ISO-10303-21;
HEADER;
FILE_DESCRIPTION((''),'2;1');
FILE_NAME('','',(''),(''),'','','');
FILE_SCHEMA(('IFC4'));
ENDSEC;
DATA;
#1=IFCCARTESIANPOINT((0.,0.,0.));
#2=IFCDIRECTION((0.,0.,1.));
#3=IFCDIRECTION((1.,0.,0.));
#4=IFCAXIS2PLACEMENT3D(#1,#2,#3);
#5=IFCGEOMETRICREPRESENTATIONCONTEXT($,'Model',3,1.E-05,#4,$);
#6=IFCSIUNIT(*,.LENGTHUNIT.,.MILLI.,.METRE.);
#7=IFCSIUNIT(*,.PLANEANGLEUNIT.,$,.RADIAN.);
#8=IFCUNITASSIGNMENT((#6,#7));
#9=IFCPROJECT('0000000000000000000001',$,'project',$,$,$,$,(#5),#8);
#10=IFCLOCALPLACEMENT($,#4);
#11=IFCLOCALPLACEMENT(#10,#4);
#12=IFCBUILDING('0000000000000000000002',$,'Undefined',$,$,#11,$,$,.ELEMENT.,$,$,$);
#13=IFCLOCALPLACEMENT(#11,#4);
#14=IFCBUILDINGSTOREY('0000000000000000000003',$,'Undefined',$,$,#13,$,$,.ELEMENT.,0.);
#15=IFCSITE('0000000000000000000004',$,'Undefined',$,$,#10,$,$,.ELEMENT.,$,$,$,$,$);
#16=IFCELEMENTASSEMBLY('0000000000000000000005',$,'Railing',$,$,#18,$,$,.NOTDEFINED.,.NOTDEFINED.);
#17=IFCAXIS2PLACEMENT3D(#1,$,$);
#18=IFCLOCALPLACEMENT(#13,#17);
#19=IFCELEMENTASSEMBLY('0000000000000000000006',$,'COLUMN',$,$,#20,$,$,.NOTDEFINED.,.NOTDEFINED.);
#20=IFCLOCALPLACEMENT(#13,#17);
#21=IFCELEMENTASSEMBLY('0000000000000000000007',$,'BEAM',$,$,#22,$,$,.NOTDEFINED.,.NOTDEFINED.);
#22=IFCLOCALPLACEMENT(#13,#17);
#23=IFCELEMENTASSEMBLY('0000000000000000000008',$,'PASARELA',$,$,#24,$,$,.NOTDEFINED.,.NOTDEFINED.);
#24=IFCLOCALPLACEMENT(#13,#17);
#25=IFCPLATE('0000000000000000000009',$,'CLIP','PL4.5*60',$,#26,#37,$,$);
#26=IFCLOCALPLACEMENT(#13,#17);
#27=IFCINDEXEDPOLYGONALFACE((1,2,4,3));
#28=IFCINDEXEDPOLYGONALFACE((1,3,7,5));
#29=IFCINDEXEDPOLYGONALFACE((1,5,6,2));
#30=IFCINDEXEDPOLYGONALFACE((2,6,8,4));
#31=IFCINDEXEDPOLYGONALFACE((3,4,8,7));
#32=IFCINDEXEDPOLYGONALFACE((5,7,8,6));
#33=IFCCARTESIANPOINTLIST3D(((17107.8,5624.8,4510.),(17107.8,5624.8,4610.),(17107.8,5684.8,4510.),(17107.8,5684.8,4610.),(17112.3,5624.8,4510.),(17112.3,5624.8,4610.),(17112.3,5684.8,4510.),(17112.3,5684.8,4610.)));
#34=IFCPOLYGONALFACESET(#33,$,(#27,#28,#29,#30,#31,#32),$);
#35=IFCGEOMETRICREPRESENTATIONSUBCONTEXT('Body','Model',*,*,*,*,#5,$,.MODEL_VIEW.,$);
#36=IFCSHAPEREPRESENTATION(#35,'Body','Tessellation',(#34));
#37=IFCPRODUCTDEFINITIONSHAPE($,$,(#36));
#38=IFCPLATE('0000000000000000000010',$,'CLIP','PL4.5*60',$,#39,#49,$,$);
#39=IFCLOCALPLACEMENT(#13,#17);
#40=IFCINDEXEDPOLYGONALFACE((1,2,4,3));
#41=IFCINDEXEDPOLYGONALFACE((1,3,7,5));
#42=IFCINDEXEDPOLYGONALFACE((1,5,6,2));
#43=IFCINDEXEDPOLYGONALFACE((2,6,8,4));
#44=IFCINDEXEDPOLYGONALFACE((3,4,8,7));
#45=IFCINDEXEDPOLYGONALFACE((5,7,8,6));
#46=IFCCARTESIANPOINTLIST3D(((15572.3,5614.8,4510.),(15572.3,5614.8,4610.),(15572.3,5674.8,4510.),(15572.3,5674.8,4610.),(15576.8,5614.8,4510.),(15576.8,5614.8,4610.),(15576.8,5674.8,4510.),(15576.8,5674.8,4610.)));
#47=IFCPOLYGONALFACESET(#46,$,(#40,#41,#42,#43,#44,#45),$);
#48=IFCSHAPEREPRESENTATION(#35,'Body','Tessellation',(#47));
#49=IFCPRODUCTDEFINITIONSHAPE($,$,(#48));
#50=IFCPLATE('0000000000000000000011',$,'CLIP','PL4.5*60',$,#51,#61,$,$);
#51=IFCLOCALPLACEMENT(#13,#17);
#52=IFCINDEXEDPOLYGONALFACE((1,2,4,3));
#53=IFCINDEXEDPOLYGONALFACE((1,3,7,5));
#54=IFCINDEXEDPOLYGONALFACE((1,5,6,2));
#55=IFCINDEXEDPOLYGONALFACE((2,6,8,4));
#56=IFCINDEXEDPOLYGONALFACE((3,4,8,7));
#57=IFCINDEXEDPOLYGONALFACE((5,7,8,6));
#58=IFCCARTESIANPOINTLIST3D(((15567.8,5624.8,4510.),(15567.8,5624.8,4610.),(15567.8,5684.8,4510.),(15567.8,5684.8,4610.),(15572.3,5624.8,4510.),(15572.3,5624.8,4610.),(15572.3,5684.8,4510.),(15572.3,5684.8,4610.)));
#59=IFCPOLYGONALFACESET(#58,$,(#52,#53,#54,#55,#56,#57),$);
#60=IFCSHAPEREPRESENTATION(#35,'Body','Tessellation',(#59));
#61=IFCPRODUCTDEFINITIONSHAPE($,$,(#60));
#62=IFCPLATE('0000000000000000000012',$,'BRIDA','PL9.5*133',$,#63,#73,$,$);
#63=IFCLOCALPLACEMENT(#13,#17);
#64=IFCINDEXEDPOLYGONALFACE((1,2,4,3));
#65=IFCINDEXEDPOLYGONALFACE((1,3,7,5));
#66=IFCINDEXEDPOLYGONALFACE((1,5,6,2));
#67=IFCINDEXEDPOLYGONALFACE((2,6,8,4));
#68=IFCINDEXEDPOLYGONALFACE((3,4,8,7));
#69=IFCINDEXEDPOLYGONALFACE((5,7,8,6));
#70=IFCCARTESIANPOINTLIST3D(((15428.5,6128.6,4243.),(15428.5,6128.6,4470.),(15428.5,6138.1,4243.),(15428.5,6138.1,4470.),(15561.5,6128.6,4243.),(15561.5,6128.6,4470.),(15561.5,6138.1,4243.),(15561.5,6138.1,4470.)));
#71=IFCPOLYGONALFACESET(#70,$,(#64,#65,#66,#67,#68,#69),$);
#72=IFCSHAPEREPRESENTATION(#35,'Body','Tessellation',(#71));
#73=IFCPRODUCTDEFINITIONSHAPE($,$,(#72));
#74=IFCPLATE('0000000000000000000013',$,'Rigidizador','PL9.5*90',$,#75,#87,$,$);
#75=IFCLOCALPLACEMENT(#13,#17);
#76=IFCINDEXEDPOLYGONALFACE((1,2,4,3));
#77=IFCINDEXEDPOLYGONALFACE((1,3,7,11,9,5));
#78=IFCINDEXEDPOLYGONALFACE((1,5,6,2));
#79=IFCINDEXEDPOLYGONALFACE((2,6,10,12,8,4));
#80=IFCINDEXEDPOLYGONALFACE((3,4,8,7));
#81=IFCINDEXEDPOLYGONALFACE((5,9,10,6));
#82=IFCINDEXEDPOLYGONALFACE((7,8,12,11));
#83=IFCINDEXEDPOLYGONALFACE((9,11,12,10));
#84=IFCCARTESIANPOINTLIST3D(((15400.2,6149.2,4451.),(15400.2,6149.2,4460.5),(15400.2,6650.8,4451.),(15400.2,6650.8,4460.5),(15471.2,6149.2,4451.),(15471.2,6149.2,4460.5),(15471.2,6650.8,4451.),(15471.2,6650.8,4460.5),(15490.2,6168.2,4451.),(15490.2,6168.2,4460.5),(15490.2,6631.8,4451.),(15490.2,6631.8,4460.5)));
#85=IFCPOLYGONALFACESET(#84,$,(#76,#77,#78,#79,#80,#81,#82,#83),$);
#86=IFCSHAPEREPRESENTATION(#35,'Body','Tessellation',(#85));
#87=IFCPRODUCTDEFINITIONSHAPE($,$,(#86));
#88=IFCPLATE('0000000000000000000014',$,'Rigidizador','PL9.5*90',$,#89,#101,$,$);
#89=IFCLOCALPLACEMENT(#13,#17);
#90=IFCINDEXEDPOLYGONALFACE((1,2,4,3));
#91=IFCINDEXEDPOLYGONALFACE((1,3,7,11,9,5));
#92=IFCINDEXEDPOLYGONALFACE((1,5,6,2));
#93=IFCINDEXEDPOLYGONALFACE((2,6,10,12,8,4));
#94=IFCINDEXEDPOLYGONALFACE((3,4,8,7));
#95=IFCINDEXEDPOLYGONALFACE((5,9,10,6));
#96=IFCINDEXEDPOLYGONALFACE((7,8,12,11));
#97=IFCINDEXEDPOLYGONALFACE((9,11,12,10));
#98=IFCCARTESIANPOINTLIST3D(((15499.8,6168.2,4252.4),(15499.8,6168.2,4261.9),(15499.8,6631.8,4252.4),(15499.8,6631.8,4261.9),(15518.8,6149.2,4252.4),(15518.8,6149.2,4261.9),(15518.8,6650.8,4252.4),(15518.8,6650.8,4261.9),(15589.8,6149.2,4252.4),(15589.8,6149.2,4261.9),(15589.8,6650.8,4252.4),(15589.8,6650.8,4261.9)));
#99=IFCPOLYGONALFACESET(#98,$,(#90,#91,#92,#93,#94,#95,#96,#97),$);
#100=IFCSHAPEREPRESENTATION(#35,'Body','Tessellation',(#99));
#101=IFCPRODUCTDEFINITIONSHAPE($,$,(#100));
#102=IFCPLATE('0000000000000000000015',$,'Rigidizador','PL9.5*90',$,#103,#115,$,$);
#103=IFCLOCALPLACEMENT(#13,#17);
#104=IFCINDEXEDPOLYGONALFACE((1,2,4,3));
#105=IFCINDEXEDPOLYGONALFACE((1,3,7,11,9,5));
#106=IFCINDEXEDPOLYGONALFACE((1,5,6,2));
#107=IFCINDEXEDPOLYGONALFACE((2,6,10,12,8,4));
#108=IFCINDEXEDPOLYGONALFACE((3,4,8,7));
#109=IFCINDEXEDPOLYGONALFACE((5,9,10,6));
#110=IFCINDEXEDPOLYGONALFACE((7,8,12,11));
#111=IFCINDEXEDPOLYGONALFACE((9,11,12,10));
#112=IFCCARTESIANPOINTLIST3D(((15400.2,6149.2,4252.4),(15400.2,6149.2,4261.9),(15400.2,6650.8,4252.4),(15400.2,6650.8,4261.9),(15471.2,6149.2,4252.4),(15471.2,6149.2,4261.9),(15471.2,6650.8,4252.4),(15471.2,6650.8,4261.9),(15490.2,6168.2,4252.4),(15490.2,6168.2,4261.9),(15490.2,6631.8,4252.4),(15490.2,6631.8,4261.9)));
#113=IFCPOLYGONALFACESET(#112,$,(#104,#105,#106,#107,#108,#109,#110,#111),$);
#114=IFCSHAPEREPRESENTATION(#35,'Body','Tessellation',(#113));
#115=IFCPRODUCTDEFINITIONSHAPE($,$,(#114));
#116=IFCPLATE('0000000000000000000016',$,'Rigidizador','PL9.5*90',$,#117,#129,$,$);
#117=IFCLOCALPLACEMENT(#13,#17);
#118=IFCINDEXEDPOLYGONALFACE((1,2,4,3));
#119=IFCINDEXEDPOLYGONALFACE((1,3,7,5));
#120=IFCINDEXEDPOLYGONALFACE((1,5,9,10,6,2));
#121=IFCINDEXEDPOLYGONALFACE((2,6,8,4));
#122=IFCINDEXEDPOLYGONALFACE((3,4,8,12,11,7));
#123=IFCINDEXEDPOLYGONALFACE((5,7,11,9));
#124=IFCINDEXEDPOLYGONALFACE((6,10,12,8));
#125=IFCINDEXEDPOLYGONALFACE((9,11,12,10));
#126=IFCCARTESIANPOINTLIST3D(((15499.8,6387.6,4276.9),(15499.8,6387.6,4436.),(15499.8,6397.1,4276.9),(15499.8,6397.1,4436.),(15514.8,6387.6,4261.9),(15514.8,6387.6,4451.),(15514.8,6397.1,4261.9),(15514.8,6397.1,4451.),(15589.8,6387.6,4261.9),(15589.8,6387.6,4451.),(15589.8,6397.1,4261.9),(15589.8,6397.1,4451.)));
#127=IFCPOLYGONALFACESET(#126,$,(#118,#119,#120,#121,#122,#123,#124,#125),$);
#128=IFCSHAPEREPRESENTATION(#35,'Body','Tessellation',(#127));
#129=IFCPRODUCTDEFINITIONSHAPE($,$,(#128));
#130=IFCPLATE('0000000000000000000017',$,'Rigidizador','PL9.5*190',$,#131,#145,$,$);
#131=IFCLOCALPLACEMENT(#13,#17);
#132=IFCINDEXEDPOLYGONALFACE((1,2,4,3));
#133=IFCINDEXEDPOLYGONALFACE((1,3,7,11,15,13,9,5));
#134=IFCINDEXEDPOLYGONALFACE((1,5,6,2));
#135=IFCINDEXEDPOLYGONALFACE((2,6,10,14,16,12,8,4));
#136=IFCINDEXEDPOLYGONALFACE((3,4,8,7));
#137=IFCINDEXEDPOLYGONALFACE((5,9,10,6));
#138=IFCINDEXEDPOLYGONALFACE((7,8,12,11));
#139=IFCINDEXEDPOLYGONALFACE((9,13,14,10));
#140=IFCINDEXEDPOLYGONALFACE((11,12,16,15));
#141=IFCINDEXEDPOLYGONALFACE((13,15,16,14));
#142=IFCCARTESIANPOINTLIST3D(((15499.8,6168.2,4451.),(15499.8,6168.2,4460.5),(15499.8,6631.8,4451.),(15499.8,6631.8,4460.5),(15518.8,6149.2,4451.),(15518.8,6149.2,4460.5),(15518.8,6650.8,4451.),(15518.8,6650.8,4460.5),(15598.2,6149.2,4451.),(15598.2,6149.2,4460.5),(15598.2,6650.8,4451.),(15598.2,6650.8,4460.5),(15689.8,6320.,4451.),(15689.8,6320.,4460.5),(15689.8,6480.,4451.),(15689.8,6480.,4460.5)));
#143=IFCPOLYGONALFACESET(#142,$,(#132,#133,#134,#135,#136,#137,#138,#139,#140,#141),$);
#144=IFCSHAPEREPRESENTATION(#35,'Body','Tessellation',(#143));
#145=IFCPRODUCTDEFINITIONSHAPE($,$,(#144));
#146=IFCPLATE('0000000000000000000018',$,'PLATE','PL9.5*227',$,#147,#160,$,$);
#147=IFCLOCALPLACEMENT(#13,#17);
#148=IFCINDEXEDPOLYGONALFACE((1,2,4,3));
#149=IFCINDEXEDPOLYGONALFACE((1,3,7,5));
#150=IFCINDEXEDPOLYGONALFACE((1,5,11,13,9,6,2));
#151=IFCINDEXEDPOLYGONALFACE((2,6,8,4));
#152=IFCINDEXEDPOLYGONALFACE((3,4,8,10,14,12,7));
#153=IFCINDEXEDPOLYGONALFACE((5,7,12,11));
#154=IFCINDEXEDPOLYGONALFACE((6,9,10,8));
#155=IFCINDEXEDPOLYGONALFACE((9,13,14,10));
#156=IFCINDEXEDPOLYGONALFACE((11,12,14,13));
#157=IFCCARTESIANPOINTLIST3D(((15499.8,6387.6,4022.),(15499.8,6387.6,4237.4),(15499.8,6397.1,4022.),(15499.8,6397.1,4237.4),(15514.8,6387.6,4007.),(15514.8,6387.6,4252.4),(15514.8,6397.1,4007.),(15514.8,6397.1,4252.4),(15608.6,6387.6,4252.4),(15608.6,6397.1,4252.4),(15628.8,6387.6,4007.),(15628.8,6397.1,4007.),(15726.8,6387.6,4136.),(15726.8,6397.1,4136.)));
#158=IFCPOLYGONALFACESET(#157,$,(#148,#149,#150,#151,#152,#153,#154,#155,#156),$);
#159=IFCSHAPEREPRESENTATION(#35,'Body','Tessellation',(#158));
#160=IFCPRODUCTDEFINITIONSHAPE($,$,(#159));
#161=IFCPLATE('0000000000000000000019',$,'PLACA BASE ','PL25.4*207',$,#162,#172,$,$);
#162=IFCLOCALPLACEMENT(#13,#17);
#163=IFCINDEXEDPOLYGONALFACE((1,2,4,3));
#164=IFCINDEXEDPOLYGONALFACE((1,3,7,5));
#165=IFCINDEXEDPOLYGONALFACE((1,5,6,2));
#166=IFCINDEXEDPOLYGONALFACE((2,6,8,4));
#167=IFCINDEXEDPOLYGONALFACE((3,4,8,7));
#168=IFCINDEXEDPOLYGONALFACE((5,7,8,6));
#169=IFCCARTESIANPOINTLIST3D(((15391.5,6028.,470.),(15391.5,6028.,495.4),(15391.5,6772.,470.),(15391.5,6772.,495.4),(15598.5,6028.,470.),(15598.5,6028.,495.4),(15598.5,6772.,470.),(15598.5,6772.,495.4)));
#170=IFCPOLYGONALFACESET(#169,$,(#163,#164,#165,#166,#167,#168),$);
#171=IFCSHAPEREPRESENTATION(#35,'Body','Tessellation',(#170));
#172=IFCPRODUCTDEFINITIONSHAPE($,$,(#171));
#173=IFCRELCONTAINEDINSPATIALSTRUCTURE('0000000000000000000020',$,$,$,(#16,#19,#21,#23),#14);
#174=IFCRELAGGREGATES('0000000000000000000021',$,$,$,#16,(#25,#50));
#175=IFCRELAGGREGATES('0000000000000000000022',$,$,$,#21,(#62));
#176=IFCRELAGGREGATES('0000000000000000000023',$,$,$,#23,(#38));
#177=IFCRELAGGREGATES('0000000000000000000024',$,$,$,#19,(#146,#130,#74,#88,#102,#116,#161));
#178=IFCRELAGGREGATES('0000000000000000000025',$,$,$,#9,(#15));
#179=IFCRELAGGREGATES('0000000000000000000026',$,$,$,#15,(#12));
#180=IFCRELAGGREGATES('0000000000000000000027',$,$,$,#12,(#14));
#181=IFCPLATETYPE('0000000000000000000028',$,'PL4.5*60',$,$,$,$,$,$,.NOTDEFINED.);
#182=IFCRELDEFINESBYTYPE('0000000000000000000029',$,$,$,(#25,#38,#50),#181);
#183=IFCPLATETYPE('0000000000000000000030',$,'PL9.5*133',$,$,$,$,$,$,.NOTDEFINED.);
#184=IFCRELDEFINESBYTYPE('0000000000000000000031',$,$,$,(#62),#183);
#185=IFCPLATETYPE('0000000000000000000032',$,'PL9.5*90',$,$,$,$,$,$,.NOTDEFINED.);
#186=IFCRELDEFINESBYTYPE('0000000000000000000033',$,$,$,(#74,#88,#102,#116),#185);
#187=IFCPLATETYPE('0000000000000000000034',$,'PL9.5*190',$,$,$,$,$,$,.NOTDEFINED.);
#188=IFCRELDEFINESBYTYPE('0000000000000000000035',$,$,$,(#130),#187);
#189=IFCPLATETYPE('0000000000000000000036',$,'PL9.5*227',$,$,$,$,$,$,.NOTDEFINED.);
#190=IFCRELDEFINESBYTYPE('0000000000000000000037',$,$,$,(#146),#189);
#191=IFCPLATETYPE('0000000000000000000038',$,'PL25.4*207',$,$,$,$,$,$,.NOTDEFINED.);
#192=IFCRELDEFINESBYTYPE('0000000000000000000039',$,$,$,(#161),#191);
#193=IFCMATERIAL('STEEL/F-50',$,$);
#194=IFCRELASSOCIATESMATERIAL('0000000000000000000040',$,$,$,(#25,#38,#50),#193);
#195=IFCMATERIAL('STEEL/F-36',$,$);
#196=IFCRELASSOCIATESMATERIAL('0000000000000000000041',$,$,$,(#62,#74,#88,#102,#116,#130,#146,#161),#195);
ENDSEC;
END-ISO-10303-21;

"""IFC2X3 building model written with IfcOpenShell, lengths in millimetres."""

from ifc_helpers import new_model, si_unit, frame, origin_with_axes, place, context, subcontext, project, spatial, polyline, outline, extrude, material, type_object, element, aggregate, save


model = new_model("IFC2X3")

# Units and contexts
model_context = context("Model", 3, precision=1e-05, world=origin_with_axes())
body_context = subcontext(model_context, "Body", "Model", "MODEL_VIEW")
ifc_project = project(units=[si_unit("LENGTHUNIT", "METRE", prefix="MILLI"), si_unit("PLANEANGLEUNIT", "RADIAN")], contexts=[model_context])

# Site, building, storey
site_placement = place(None, origin_with_axes())
site = spatial("IfcSite", under=ifc_project, at=site_placement, Name="Undefined", CompositionType="ELEMENT")
building_placement = place(site_placement, origin_with_axes())
building = spatial("IfcBuilding", under=site, at=building_placement, Name="Undefined", CompositionType="ELEMENT")
storey_placement = place(building_placement, origin_with_axes())
storey = spatial("IfcBuildingStorey", under=building, at=storey_placement, Name="Undefined", CompositionType="ELEMENT", Elevation=0.0)

# Element assembly
assembly_1_placement = place(storey_placement, origin_with_axes())
assembly_1 = element("IfcElementAssembly", 1, at=assembly_1_placement, inside=storey, Name="Railing", AssemblyPlace="NOTDEFINED", PredefinedType="NOTDEFINED")

# Element assembly
assembly_2_placement = place(storey_placement, origin_with_axes())
assembly_2 = element("IfcElementAssembly", 2, at=assembly_2_placement, inside=storey, Name="COLUMN", AssemblyPlace="NOTDEFINED", PredefinedType="NOTDEFINED")
ifc_material_1 = material(Name="STEEL/F-36")

# Element assembly
assembly_3_placement = place(storey_placement, origin_with_axes())
assembly_3 = element("IfcElementAssembly", 3, at=assembly_3_placement, inside=storey, Name="BEAM", AssemblyPlace="NOTDEFINED", PredefinedType="NOTDEFINED")

# Element assembly
assembly_4_placement = place(storey_placement, origin_with_axes())
assembly_4 = element("IfcElementAssembly", 4, at=assembly_4_placement, inside=storey, Name="PASARELA", AssemblyPlace="NOTDEFINED", PredefinedType="NOTDEFINED")
ifc_material_2 = material(Name="STEEL/F-50")
plate_type_1 = type_object("IfcPlateType", Name="PL4.5*60", PredefinedType="NOTDEFINED")

# Plates
plate_1_placement = place(assembly_1_placement, frame((17110.0, 5684.8, 4510.0), z_axis=(-1.0, 0.0, 0.0), x_axis=(0.000001, -1.0, 0.000014)))
plate_1 = element("IfcPlate", 5, at=plate_1_placement, type_object=plate_type_1, material=ifc_material_2, Name="CLIP", Description="PL4.5*60", context=body_context, shape_type="SweptSolid", body=[
    extrude(outline(polyline([(0.0, 0.0), (60.0, 0.0), (60.0, 100.0), (0.0, 100.0), (0.0, 0.0)])), frame((0.0, 0.0, -2.2), z_axis=(0.0, 0.0, 1.0), x_axis=(1.0, 0.0, 0.0)), (0.0, 0.0, 1.0), 4.5),
])
plate_2_placement = place(assembly_4_placement, frame((15574.5, 5674.8, 4510.0), z_axis=(-1.0, 0.0, 0.0), x_axis=(0.000001, -1.0, 0.000014)))
plate_2 = element("IfcPlate", 6, at=plate_2_placement, type_object=plate_type_1, material=ifc_material_2, Name="CLIP", Description="PL4.5*60", context=body_context, shape_type="SweptSolid", body=[
    extrude(outline(polyline([(0.0, 0.0), (60.0, 0.0), (60.0, 100.0), (0.0, 100.0), (0.0, 0.0)])), frame((0.0, 0.0, -2.2), z_axis=(0.0, 0.0, 1.0), x_axis=(1.0, 0.0, 0.0)), (0.0, 0.0, 1.0), 4.5),
])
plate_3_placement = place(assembly_1_placement, frame((15570.0, 5684.8, 4510.0), z_axis=(-1.0, 0.0, 0.0), x_axis=(0.000001, -1.0, 0.000014)))
plate_3 = element("IfcPlate", 7, at=plate_3_placement, type_object=plate_type_1, material=ifc_material_2, Name="CLIP", Description="PL4.5*60", context=body_context, shape_type="SweptSolid", body=[
    extrude(outline(polyline([(0.0, 0.0), (60.0, 0.0), (60.0, 100.0), (0.0, 100.0), (0.0, 0.0)])), frame((0.0, 0.0, -2.2), z_axis=(0.0, 0.0, 1.0), x_axis=(1.0, 0.0, 0.0)), (0.0, 0.0, 1.0), 4.5),
])
aggregate(assembly_1, [plate_1, plate_3])
plate_type_2 = type_object("IfcPlateType", Name="PL9.5*133", PredefinedType="NOTDEFINED")
plate_4_placement = place(assembly_3_placement, frame((15495.0, 6133.3, 4243.0), z_axis=(0.0, -1.0, 0.0), x_axis=(0.0, 0.0, 1.0)))
plate_4 = element("IfcPlate", 8, at=plate_4_placement, type_object=plate_type_2, material=ifc_material_1, Name="BRIDA", Description="PL9.5*133", context=body_context, shape_type="SweptSolid", body=[
    extrude(outline(polyline([(0.0, -66.5), (0.0, 66.5), (227.0, 66.5), (227.0, -66.5), (0.0, -66.5)])), frame((0.0, 0.0, -4.8), z_axis=(0.0, 0.0, 1.0), x_axis=(1.0, 0.0, 0.0)), (0.0, 0.0, 1.0), 9.5),
])
aggregate(assembly_3, [plate_4])
plate_type_3 = type_object("IfcPlateType", Name="PL9.5*90", PredefinedType="NOTDEFINED")
plate_5_placement = place(assembly_2_placement, frame((15490.2, 6650.8, 4455.8), z_axis=(0.0, 0.0, 1.0), x_axis=(-1.0, 0.0, 0.0)))
plate_5 = element("IfcPlate", 9, at=plate_5_placement, type_object=plate_type_3, material=ifc_material_1, Name="Rigidizador", Description="PL9.5*90", context=body_context, shape_type="SweptSolid", body=[
    extrude(outline(polyline([(0.0, 19.0), (19.0, 0.0), (90.0, 0.0), (90.0, 501.6), (19.0, 501.6), (0.0, 482.6), (0.0, 19.0)])), frame((0.0, 0.0, -4.8), z_axis=(0.0, 0.0, 1.0), x_axis=(1.0, 0.0, 0.0)), (0.0, 0.0, 1.0), 9.5),
])
plate_6_placement = place(assembly_2_placement, frame((15589.8, 6650.8, 4257.2), z_axis=(0.0, 0.0, 1.0), x_axis=(-1.0, 0.0, 0.0)))
plate_6 = element("IfcPlate", 10, at=plate_6_placement, type_object=plate_type_3, material=ifc_material_1, Name="Rigidizador", Description="PL9.5*90", context=body_context, shape_type="SweptSolid", body=[
    extrude(outline(polyline([(0.0, 0.0), (71.0, 0.0), (90.0, 19.0), (90.0, 482.6), (71.0, 501.6), (0.0, 501.6), (0.0, 0.0)])), frame((0.0, 0.0, -4.8), z_axis=(0.0, 0.0, 1.0), x_axis=(1.0, 0.0, 0.0)), (0.0, 0.0, 1.0), 9.5),
])
plate_7_placement = place(assembly_2_placement, frame((15490.2, 6650.8, 4257.2), z_axis=(0.0, 0.0, 1.0), x_axis=(-1.0, 0.0, 0.0)))
plate_7 = element("IfcPlate", 11, at=plate_7_placement, type_object=plate_type_3, material=ifc_material_1, Name="Rigidizador", Description="PL9.5*90", context=body_context, shape_type="SweptSolid", body=[
    extrude(outline(polyline([(0.0, 19.0), (19.0, 0.0), (90.0, 0.0), (90.0, 501.6), (19.0, 501.6), (0.0, 482.6), (0.0, 19.0)])), frame((0.0, 0.0, -4.8), z_axis=(0.0, 0.0, 1.0), x_axis=(1.0, 0.0, 0.0)), (0.0, 0.0, 1.0), 9.5),
])
plate_8_placement = place(assembly_2_placement, frame((15589.8, 6392.4, 4451.0), z_axis=(0.0, -1.0, 0.0), x_axis=(-1.0, 0.0, -0.000004)))
plate_8 = element("IfcPlate", 12, at=plate_8_placement, type_object=plate_type_3, material=ifc_material_1, Name="Rigidizador", Description="PL9.5*90", context=body_context, shape_type="SweptSolid", body=[
    extrude(outline(polyline([(0.0, 0.0), (75.0, 0.0), (90.0, 15.0), (90.0, 174.1), (75.0, 189.1), (0.0, 189.1), (0.0, 0.0)])), frame((0.0, 0.0, -4.8), z_axis=(0.0, 0.0, 1.0), x_axis=(1.0, 0.0, 0.0)), (0.0, 0.0, 1.0), 9.5),
])
plate_type_4 = type_object("IfcPlateType", Name="PL9.5*190", PredefinedType="NOTDEFINED")
plate_9_placement = place(assembly_2_placement, frame((15598.2, 6650.8, 4455.8), z_axis=(0.0, 0.0, 1.0), x_axis=(-1.0, 0.0, 0.0)))
plate_9 = element("IfcPlate", 13, at=plate_9_placement, type_object=plate_type_4, material=ifc_material_1, Name="Rigidizador", Description="PL9.5*190", context=body_context, shape_type="SweptSolid", body=[
    extrude(outline(polyline([(0.0, 0.0), (79.4, 0.0), (98.4, 19.0), (98.4, 482.6), (79.4, 501.6), (0.0, 501.6), (-91.6, 330.8), (-91.6, 170.8), (0.0, 0.0)])), frame((0.0, 0.0, -4.8), z_axis=(0.0, 0.0, 1.0), x_axis=(1.0, 0.0, 0.0)), (0.0, 0.0, 1.0), 9.5),
])
plate_type_5 = type_object("IfcPlateType", Name="PL9.5*227", PredefinedType="NOTDEFINED")
plate_10_placement = place(assembly_2_placement, frame((15628.8, 6392.3, 4007.0), z_axis=(-0.000001, 1.0, 0.000001), x_axis=(-1.0, 0.0, 0.0)))
plate_10 = element("IfcPlate", 14, at=plate_10_placement, type_object=plate_type_5, material=ifc_material_1, Name="PLATE", Description="PL9.5*227", context=body_context, shape_type="SweptSolid", body=[
    extrude(outline(polyline([(0.0, 0.0), (114.0, 0.0), (129.0, 15.0), (129.0, 230.4), (114.0, 245.4), (20.2, 245.4), (-98.0, 129.0), (0.0, 0.0)])), frame((0.0, 0.0, -4.8), z_axis=(0.0, 0.0, 1.0), x_axis=(1.0, 0.0, 0.0)), (0.0, 0.0, 1.0), 9.5),
])
plate_type_6 = type_object("IfcPlateType", Name="PL25.4*207", PredefinedType="NOTDEFINED")
plate_11_placement = place(assembly_2_placement, frame((15495.0, 6028.0, 482.7), z_axis=(0.0, 0.0, 1.0), x_axis=(0.0, 1.0, 0.0)))
plate_11 = element("IfcPlate", 15, at=plate_11_placement, type_object=plate_type_6, material=ifc_material_1, Name="PLACA BASE ", Description="PL25.4*207", context=body_context, shape_type="SweptSolid", body=[
    extrude(outline(polyline([(0.0, -103.5), (0.0, 103.5), (744.0, 103.5), (744.0, -103.5), (0.0, -103.5)])), frame((0.0, 0.0, -12.7), z_axis=(0.0, 0.0, 1.0), x_axis=(1.0, 0.0, 0.0)), (0.0, 0.0, 1.0), 25.4),
])

aggregate(assembly_4, [plate_2])

aggregate(assembly_2, [plate_10, plate_9, plate_5, plate_6, plate_7, plate_8, plate_11])

save(model, "model.ifc")
